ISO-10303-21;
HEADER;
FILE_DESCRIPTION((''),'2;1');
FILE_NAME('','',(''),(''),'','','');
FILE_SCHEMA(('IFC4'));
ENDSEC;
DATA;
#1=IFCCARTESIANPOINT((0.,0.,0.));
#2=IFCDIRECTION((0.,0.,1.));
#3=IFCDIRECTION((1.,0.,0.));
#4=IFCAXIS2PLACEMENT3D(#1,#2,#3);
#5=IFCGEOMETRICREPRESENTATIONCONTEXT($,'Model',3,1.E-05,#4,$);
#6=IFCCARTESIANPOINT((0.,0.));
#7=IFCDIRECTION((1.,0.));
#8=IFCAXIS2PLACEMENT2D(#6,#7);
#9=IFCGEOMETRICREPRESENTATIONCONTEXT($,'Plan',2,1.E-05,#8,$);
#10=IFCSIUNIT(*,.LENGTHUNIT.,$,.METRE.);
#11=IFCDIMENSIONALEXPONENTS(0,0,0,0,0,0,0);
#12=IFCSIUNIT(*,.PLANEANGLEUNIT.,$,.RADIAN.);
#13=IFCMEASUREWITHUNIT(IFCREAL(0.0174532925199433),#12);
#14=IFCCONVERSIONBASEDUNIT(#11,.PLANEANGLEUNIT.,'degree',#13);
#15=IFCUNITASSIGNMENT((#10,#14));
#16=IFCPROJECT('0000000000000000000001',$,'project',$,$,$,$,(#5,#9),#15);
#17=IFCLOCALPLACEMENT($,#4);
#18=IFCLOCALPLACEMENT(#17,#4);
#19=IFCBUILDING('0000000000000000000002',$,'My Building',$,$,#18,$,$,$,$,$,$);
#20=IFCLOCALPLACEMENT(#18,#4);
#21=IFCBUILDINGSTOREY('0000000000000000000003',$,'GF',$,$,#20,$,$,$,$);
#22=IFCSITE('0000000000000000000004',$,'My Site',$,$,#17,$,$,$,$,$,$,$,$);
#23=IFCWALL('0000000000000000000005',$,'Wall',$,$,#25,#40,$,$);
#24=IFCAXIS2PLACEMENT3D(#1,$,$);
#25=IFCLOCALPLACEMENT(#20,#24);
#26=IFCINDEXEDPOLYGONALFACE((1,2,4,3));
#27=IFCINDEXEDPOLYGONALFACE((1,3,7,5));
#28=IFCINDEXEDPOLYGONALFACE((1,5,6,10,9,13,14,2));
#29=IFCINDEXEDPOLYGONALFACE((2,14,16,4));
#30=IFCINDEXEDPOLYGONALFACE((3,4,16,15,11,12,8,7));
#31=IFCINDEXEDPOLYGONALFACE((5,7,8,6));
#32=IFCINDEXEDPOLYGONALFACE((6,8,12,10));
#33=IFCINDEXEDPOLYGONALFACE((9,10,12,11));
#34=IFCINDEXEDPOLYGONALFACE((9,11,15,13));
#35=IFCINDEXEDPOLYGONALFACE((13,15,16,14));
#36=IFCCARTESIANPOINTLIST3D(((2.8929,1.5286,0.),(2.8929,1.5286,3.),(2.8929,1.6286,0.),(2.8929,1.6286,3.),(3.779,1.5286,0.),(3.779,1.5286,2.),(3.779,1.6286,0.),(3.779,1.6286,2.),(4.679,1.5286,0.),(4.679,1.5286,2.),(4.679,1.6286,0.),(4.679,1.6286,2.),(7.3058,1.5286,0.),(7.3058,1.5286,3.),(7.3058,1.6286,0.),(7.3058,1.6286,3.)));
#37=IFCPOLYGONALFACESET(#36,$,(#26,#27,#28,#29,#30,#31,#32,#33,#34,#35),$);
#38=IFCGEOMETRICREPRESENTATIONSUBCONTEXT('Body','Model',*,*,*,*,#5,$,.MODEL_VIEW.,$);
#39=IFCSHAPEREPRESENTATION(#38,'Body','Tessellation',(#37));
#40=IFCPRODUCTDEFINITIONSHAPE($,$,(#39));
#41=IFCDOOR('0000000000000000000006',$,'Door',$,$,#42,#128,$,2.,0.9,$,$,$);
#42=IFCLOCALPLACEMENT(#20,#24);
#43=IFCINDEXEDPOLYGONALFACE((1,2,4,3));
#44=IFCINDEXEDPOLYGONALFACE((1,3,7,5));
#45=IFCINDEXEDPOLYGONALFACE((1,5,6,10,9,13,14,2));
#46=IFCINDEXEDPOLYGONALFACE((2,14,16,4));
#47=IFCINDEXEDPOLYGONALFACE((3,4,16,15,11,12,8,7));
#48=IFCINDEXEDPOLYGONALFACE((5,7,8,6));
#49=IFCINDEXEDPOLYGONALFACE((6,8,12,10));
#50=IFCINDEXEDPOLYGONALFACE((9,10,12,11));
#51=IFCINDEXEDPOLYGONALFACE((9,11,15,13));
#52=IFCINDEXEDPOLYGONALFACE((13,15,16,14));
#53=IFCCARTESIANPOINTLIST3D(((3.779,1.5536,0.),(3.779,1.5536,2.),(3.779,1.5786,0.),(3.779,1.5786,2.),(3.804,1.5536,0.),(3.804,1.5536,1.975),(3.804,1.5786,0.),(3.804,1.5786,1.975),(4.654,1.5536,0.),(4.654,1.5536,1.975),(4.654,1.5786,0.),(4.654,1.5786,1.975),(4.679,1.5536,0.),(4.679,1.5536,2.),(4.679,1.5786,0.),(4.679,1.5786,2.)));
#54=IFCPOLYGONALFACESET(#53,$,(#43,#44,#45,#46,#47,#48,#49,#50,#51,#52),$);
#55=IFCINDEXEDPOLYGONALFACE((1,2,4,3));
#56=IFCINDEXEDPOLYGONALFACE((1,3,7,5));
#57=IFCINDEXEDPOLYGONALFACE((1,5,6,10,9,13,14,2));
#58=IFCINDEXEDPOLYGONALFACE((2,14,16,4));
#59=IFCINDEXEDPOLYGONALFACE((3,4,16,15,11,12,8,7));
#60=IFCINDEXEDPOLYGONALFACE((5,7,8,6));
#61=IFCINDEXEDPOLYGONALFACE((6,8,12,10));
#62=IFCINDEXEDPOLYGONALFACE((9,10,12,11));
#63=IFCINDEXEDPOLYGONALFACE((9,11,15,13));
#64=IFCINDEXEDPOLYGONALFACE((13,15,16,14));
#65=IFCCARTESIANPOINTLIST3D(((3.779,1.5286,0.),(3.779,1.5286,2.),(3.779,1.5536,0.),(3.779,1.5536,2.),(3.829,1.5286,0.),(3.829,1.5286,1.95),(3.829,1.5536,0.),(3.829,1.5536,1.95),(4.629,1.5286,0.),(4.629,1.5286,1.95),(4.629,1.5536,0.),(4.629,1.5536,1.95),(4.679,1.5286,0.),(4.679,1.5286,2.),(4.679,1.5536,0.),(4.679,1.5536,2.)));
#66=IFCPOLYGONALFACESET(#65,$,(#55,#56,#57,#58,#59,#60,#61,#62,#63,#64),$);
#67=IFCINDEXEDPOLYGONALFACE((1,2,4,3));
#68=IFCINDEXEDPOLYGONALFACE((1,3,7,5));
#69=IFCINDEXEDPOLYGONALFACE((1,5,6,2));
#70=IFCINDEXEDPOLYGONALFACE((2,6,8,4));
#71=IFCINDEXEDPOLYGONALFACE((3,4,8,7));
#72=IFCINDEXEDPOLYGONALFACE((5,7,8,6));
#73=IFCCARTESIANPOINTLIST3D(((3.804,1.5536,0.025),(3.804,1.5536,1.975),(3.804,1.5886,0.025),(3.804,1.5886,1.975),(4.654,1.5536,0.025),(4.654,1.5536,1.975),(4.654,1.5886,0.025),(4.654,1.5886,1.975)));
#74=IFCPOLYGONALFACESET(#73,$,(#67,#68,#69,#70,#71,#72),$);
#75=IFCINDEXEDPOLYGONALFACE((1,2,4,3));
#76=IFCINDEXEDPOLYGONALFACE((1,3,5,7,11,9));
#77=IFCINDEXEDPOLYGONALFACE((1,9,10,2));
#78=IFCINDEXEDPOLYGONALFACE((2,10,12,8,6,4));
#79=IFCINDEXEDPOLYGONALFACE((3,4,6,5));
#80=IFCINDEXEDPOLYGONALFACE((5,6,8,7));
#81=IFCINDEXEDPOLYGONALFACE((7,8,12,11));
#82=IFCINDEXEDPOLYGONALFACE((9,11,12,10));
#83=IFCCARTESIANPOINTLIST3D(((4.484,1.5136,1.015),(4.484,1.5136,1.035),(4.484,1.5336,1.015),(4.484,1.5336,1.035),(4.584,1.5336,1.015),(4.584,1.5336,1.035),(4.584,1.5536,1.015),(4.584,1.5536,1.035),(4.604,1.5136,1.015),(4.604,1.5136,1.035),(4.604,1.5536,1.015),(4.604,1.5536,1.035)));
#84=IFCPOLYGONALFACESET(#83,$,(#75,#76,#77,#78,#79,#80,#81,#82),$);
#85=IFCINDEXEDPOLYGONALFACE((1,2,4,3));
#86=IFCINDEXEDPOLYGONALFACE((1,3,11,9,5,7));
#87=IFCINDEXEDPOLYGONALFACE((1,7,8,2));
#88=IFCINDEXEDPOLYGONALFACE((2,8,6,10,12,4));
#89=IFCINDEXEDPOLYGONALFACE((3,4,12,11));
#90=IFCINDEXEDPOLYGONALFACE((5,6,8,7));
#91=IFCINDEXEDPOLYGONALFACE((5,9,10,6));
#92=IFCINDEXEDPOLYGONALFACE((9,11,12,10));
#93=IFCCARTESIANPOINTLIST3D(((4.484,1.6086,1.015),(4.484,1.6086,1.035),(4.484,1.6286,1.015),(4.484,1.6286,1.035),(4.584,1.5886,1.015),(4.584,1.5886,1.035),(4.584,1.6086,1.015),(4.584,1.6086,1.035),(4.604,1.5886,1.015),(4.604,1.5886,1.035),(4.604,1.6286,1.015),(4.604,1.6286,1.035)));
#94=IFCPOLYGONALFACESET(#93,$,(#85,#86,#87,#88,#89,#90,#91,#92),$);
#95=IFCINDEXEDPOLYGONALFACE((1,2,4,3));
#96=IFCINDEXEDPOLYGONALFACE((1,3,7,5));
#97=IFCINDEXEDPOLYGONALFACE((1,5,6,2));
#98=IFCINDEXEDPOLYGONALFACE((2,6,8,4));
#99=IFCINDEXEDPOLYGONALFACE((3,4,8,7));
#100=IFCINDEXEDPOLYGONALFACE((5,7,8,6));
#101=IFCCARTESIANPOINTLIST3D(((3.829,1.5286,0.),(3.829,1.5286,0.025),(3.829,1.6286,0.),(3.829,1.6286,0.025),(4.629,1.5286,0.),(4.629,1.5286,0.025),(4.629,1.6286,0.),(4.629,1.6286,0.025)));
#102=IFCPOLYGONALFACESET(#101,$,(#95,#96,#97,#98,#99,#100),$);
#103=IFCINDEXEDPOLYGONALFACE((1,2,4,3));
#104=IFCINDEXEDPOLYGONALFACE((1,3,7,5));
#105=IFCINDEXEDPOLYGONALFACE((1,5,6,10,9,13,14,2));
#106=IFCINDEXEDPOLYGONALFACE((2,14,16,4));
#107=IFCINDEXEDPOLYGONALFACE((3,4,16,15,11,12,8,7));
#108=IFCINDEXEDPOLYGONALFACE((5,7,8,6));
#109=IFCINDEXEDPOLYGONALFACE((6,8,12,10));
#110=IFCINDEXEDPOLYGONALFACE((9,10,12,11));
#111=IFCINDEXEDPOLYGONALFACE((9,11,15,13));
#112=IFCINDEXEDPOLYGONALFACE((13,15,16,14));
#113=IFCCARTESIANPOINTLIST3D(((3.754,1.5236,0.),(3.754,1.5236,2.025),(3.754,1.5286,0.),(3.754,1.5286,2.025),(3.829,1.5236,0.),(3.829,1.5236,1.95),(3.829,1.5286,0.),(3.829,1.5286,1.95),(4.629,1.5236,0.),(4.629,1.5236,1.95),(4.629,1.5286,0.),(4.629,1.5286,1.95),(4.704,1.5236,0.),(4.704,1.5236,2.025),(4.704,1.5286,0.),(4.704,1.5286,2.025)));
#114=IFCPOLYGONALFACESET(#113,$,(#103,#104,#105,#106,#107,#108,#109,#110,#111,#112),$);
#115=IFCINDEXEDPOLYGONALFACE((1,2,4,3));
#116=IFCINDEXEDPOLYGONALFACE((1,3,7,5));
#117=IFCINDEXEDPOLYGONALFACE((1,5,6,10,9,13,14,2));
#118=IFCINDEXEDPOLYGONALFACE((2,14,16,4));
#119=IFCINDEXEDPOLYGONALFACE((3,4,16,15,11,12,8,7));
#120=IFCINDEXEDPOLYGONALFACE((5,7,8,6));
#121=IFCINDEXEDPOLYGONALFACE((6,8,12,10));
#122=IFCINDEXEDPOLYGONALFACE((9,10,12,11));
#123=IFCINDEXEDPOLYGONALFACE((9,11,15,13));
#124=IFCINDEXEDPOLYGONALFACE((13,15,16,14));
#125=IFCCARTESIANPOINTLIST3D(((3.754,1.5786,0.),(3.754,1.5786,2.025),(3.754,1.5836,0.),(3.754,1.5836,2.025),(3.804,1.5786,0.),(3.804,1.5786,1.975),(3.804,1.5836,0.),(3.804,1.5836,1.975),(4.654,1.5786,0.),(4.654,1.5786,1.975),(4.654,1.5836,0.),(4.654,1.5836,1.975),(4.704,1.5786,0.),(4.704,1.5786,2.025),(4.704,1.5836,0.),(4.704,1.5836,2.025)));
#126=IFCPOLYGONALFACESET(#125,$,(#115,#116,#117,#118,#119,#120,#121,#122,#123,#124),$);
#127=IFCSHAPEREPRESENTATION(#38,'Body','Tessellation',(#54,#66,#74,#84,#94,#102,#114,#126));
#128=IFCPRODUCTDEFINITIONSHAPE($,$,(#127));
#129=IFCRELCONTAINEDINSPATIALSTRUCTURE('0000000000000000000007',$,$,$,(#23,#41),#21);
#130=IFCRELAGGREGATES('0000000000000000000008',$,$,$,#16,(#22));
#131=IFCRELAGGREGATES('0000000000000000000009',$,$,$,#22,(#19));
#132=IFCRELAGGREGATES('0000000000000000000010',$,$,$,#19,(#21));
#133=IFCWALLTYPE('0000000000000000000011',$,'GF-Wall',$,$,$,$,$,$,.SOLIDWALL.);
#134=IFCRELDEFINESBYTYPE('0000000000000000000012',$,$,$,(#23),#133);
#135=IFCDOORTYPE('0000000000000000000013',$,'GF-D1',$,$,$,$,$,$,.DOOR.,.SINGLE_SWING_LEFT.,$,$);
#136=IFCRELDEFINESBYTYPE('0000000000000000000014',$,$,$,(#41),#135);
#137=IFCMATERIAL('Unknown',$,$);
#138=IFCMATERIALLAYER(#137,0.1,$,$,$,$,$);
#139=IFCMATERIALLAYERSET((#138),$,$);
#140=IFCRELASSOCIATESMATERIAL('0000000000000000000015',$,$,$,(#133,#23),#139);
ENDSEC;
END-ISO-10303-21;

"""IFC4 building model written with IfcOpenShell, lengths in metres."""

from ifc_helpers import new_model, entity, si_unit, converted_unit, frame, origin_with_axes, origin_2d_with_axis, place, context, subcontext, project, spatial, line, indexed_curve, outline, extrude, shape, source, transform, mapped, material, layer, layer_set, layer_usage, type_object, type_shapes, element, fill, save


model = new_model("IFC4")

# Units and contexts
model_context = context("Model", 3, precision=1e-05, world=origin_with_axes())
plan_context = context("Plan", 2, precision=1e-05, world=origin_2d_with_axis())
body_context_1 = subcontext(model_context, "Body", "Model", "MODEL_VIEW")
body_context_2 = subcontext(plan_context, "Body", "Plan", "PLAN_VIEW")
ifc_project = project(units=[si_unit("LENGTHUNIT", "METRE"), converted_unit("PLANEANGLEUNIT", "degree", entity("IfcReal", 0.0174532925199433), si_unit("PLANEANGLEUNIT", "RADIAN"), dimensions=[0, 0, 0, 0, 0, 0, 0])], contexts=[model_context, plan_context])

# Site, building, storey
site_placement = place(None, origin_with_axes())
site = spatial("IfcSite", under=ifc_project, at=site_placement, Name="My Site")
building_placement = place(site_placement, origin_with_axes())
building = spatial("IfcBuilding", under=site, at=building_placement, Name="My Building")
storey_placement = place(building_placement, origin_with_axes())
storey = spatial("IfcBuildingStorey", under=building, at=storey_placement, Name="GF")

# Shared definitions
ifc_material = material(Name="Unknown")

# Shared definitions
ifc_layer = layer(ifc_material, 0.1)
ifc_layer_set = layer_set([ifc_layer])
wall_type = type_object("IfcWallType", Name="GF-Wall", PredefinedType="SOLIDWALL", material=ifc_layer_set)

# Wall, opening, door
ifc_layer_usage_1 = layer_usage(ifc_layer_set, "AXIS2", "POSITIVE", 0.0)
wall_1_placement = place(storey_placement, frame((2.8929, 1.5286, 0.0), z_axis=(0.0, 0.0, 1.0), x_axis=(1.0, 0.0, 0.0)))
wall_1 = element("IfcWall", 1, at=wall_1_placement, inside=storey, type_object=wall_type, material=ifc_layer_usage_1, Name="Wall", context=body_context_1, shape_type="SweptSolid", body=[
    extrude(outline(indexed_curve([(0.0, 0.0), (0.0, 0.1), (4.4129, 0.1), (4.4129, 0.0)], segments=[line(1, 2, 3, 4, 1)])), origin_with_axes(), (0.0, 0.0, 1.0), 3.0),
])
shared_shape_1 = source(origin_with_axes(), body_context_1, "Body", "SweptSolid", [
    extrude(outline(indexed_curve([(0.0, 0.0), (0.9, 0.0), (0.9, 2.0), (0.0, 2.0)], segments=[line(1, 2, 3, 4, 1)])), frame((0.0, -0.6, 0.0), z_axis=(0.0, -1.0, 0.0), x_axis=(1.0, 0.0, 0.0)), (0.0, 0.0, -1.0), 1.2),
])
opening_1_placement = place(wall_1_placement, frame((0.8861, 0.0, 0.0), z_axis=(0.0, 0.0, 1.0), x_axis=(1.0, 0.0, 0.0)))
opening_1 = element("IfcOpeningElement", 2, at=opening_1_placement, cuts=wall_1, PredefinedType="OPENING", context=body_context_1, shape_type="MappedRepresentation", body=[
    mapped(shared_shape_1, transform((0.0, 0.0, 0.0), x_axis=(1.0, 0.0, 0.0), y_axis=(0.0, 1.0, 0.0), z_axis=(0.0, 0.0, 1.0), scale=1.0)),
])
door_type_1 = type_object("IfcDoorType", Name="GF-D1", OperationType="SINGLE_SWING_LEFT", PredefinedType="DOOR")
shared_shape_2 = source(origin_with_axes(), body_context_1, "Body", "SweptSolid", [
    extrude(outline(indexed_curve([(0.0, 0.0), (0.0, 2.0), (0.9, 2.0), (0.9, 0.0), (0.875, 0.0), (0.875, 1.975), (0.025, 1.975), (0.025, 0.0)], segments=[line(1, 2, 3, 4, 5, 6, 7, 8, 1)])), frame((0.0, 0.025, 0.0), z_axis=(0.0, -1.0, 0.0), x_axis=(1.0, 0.0, 0.0)), (0.0, 0.0, -1.0), 0.025),
    extrude(outline(indexed_curve([(0.0, 0.0), (0.0, 2.0), (0.9, 2.0), (0.9, 0.0), (0.85, 0.0), (0.85, 1.95), (0.05, 1.95), (0.05, 0.0)], segments=[line(1, 2, 3, 4, 5, 6, 7, 8, 1)])), frame((0.0, 0.0, 0.0), z_axis=(0.0, -1.0, 0.0), x_axis=(1.0, 0.0, 0.0)), (0.0, 0.0, -1.0), 0.025),
    extrude(outline(indexed_curve([(0.0, 0.0), (0.85, 0.0), (0.85, 0.035), (0.0, 0.035)], segments=[line(1, 2, 3, 4, 1)])), frame((0.025, 0.025, 0.025), z_axis=(0.0, 0.0, 1.0), x_axis=(1.0, 0.0, 0.0)), (0.0, 0.0, 1.0), 1.95),
    extrude(outline(indexed_curve([(0.0, 0.0), (0.0, -0.04), (-0.12, -0.04), (-0.12, -0.02), (-0.02, -0.02), (-0.02, 0.0)], segments=[line(1, 2, 3, 4, 5, 6, 1)])), frame((0.825, 0.025, 1.015), z_axis=(0.0, 0.0, 1.0), x_axis=(1.0, 0.0, 0.0)), (0.0, 0.0, 1.0), 0.02),
    extrude(outline(indexed_curve([(0.0, 0.0), (0.0, 0.04), (-0.12, 0.04), (-0.12, 0.02), (-0.02, 0.02), (-0.02, 0.0)], segments=[line(1, 2, 3, 4, 5, 6, 1)])), frame((0.825, 0.06, 1.015), z_axis=(0.0, 0.0, 1.0), x_axis=(1.0, 0.0, 0.0)), (0.0, 0.0, 1.0), 0.02),
    extrude(outline(indexed_curve([(0.0, 0.0), (0.8, 0.0), (0.8, 0.1), (0.0, 0.1)], segments=[line(1, 2, 3, 4, 1)])), frame((0.05, 0.0, 0.0), z_axis=(0.0, 0.0, 1.0), x_axis=(1.0, 0.0, 0.0)), (0.0, 0.0, 1.0), 0.025),
    extrude(outline(indexed_curve([(0.0, 0.0), (0.0, 2.025), (0.95, 2.025), (0.95, 0.0), (0.875, 0.0), (0.875, 1.95), (0.075, 1.95), (0.075, 0.0)], segments=[line(1, 2, 3, 4, 5, 6, 7, 8, 1)])), frame((-0.025, -0.005, 0.0), z_axis=(0.0, -1.0, 0.0), x_axis=(1.0, 0.0, 0.0)), (0.0, 0.0, -1.0), 0.005),
    extrude(outline(indexed_curve([(0.0, 0.0), (0.0, 2.025), (0.95, 2.025), (0.95, 0.0), (0.9, 0.0), (0.9, 1.975), (0.05, 1.975), (0.05, 0.0)], segments=[line(1, 2, 3, 4, 5, 6, 7, 8, 1)])), frame((-0.025, 0.05, 0.0), z_axis=(0.0, -1.0, 0.0), x_axis=(1.0, 0.0, 0.0)), (0.0, 0.0, -1.0), 0.005),
])
shared_shape_3 = source(origin_with_axes(), body_context_2, "Body", "Curve2D", [
    entity("IfcIndexedPolyCurve", entity("IfcCartesianPointList2D", [[0.0, 0.0], [0.0, 0.05], [0.025, 0.05], [0.025, 0.025], [0.05, 0.025], [0.05, 0.0]]), [entity("IfcLineIndex", [1, 2, 3, 4, 5, 6, 1])]),
    entity("IfcIndexedPolyCurve", entity("IfcCartesianPointList2D", [[0.9, 0.0], [0.9, 0.05], [0.875, 0.05], [0.875, 0.025], [0.85, 0.025], [0.85, 0.0]]), [entity("IfcLineIndex", [1, 2, 3, 4, 5, 6, 1])]),
    entity("IfcTrimmedCurve", entity("IfcEllipse", entity("IfcAxis2Placement2D", entity("IfcCartesianPoint", [0.06, 0.05]), entity("IfcDirection", [1.0, 0.0])), 0.815, 0.85), [entity("IfcCartesianPoint", [0.875, 0.05])], [entity("IfcCartesianPoint", [0.06, 0.9])], True, "CARTESIAN"),
    entity("IfcIndexedPolyCurve", entity("IfcCartesianPointList2D", [[0.025, 0.05], [0.06, 0.05], [0.06, 0.9], [0.025, 0.9]]), [entity("IfcLineIndex", [1, 2, 3, 4, 1])]),
])
type_shapes(door_type_1, [shared_shape_2, shared_shape_3])
door_1_placement = place(opening_1_placement, origin_with_axes())
door_1 = element("IfcDoor", 3, at=door_1_placement, inside=storey, type_object=door_type_1, Name="Door", OverallHeight=2.0, OverallWidth=0.9, shapes=[
    shape(body_context_1, "Body", "MappedRepresentation", [mapped(shared_shape_2, transform((0.0, 0.0, 0.0), x_axis=(1.0, 0.0, 0.0), y_axis=(0.0, 1.0, 0.0), z_axis=(0.0, 0.0, 1.0), scale=1.0))]),
    shape(body_context_2, "Body", "MappedRepresentation", [mapped(shared_shape_3, transform((0.0, 0.0, 0.0), x_axis=(1.0, 0.0, 0.0), y_axis=(0.0, 1.0, 0.0), z_axis=(0.0, 0.0, 1.0), scale=1.0))]),
])
fill(opening_1, door_1)

save(model, "model.ifc")
